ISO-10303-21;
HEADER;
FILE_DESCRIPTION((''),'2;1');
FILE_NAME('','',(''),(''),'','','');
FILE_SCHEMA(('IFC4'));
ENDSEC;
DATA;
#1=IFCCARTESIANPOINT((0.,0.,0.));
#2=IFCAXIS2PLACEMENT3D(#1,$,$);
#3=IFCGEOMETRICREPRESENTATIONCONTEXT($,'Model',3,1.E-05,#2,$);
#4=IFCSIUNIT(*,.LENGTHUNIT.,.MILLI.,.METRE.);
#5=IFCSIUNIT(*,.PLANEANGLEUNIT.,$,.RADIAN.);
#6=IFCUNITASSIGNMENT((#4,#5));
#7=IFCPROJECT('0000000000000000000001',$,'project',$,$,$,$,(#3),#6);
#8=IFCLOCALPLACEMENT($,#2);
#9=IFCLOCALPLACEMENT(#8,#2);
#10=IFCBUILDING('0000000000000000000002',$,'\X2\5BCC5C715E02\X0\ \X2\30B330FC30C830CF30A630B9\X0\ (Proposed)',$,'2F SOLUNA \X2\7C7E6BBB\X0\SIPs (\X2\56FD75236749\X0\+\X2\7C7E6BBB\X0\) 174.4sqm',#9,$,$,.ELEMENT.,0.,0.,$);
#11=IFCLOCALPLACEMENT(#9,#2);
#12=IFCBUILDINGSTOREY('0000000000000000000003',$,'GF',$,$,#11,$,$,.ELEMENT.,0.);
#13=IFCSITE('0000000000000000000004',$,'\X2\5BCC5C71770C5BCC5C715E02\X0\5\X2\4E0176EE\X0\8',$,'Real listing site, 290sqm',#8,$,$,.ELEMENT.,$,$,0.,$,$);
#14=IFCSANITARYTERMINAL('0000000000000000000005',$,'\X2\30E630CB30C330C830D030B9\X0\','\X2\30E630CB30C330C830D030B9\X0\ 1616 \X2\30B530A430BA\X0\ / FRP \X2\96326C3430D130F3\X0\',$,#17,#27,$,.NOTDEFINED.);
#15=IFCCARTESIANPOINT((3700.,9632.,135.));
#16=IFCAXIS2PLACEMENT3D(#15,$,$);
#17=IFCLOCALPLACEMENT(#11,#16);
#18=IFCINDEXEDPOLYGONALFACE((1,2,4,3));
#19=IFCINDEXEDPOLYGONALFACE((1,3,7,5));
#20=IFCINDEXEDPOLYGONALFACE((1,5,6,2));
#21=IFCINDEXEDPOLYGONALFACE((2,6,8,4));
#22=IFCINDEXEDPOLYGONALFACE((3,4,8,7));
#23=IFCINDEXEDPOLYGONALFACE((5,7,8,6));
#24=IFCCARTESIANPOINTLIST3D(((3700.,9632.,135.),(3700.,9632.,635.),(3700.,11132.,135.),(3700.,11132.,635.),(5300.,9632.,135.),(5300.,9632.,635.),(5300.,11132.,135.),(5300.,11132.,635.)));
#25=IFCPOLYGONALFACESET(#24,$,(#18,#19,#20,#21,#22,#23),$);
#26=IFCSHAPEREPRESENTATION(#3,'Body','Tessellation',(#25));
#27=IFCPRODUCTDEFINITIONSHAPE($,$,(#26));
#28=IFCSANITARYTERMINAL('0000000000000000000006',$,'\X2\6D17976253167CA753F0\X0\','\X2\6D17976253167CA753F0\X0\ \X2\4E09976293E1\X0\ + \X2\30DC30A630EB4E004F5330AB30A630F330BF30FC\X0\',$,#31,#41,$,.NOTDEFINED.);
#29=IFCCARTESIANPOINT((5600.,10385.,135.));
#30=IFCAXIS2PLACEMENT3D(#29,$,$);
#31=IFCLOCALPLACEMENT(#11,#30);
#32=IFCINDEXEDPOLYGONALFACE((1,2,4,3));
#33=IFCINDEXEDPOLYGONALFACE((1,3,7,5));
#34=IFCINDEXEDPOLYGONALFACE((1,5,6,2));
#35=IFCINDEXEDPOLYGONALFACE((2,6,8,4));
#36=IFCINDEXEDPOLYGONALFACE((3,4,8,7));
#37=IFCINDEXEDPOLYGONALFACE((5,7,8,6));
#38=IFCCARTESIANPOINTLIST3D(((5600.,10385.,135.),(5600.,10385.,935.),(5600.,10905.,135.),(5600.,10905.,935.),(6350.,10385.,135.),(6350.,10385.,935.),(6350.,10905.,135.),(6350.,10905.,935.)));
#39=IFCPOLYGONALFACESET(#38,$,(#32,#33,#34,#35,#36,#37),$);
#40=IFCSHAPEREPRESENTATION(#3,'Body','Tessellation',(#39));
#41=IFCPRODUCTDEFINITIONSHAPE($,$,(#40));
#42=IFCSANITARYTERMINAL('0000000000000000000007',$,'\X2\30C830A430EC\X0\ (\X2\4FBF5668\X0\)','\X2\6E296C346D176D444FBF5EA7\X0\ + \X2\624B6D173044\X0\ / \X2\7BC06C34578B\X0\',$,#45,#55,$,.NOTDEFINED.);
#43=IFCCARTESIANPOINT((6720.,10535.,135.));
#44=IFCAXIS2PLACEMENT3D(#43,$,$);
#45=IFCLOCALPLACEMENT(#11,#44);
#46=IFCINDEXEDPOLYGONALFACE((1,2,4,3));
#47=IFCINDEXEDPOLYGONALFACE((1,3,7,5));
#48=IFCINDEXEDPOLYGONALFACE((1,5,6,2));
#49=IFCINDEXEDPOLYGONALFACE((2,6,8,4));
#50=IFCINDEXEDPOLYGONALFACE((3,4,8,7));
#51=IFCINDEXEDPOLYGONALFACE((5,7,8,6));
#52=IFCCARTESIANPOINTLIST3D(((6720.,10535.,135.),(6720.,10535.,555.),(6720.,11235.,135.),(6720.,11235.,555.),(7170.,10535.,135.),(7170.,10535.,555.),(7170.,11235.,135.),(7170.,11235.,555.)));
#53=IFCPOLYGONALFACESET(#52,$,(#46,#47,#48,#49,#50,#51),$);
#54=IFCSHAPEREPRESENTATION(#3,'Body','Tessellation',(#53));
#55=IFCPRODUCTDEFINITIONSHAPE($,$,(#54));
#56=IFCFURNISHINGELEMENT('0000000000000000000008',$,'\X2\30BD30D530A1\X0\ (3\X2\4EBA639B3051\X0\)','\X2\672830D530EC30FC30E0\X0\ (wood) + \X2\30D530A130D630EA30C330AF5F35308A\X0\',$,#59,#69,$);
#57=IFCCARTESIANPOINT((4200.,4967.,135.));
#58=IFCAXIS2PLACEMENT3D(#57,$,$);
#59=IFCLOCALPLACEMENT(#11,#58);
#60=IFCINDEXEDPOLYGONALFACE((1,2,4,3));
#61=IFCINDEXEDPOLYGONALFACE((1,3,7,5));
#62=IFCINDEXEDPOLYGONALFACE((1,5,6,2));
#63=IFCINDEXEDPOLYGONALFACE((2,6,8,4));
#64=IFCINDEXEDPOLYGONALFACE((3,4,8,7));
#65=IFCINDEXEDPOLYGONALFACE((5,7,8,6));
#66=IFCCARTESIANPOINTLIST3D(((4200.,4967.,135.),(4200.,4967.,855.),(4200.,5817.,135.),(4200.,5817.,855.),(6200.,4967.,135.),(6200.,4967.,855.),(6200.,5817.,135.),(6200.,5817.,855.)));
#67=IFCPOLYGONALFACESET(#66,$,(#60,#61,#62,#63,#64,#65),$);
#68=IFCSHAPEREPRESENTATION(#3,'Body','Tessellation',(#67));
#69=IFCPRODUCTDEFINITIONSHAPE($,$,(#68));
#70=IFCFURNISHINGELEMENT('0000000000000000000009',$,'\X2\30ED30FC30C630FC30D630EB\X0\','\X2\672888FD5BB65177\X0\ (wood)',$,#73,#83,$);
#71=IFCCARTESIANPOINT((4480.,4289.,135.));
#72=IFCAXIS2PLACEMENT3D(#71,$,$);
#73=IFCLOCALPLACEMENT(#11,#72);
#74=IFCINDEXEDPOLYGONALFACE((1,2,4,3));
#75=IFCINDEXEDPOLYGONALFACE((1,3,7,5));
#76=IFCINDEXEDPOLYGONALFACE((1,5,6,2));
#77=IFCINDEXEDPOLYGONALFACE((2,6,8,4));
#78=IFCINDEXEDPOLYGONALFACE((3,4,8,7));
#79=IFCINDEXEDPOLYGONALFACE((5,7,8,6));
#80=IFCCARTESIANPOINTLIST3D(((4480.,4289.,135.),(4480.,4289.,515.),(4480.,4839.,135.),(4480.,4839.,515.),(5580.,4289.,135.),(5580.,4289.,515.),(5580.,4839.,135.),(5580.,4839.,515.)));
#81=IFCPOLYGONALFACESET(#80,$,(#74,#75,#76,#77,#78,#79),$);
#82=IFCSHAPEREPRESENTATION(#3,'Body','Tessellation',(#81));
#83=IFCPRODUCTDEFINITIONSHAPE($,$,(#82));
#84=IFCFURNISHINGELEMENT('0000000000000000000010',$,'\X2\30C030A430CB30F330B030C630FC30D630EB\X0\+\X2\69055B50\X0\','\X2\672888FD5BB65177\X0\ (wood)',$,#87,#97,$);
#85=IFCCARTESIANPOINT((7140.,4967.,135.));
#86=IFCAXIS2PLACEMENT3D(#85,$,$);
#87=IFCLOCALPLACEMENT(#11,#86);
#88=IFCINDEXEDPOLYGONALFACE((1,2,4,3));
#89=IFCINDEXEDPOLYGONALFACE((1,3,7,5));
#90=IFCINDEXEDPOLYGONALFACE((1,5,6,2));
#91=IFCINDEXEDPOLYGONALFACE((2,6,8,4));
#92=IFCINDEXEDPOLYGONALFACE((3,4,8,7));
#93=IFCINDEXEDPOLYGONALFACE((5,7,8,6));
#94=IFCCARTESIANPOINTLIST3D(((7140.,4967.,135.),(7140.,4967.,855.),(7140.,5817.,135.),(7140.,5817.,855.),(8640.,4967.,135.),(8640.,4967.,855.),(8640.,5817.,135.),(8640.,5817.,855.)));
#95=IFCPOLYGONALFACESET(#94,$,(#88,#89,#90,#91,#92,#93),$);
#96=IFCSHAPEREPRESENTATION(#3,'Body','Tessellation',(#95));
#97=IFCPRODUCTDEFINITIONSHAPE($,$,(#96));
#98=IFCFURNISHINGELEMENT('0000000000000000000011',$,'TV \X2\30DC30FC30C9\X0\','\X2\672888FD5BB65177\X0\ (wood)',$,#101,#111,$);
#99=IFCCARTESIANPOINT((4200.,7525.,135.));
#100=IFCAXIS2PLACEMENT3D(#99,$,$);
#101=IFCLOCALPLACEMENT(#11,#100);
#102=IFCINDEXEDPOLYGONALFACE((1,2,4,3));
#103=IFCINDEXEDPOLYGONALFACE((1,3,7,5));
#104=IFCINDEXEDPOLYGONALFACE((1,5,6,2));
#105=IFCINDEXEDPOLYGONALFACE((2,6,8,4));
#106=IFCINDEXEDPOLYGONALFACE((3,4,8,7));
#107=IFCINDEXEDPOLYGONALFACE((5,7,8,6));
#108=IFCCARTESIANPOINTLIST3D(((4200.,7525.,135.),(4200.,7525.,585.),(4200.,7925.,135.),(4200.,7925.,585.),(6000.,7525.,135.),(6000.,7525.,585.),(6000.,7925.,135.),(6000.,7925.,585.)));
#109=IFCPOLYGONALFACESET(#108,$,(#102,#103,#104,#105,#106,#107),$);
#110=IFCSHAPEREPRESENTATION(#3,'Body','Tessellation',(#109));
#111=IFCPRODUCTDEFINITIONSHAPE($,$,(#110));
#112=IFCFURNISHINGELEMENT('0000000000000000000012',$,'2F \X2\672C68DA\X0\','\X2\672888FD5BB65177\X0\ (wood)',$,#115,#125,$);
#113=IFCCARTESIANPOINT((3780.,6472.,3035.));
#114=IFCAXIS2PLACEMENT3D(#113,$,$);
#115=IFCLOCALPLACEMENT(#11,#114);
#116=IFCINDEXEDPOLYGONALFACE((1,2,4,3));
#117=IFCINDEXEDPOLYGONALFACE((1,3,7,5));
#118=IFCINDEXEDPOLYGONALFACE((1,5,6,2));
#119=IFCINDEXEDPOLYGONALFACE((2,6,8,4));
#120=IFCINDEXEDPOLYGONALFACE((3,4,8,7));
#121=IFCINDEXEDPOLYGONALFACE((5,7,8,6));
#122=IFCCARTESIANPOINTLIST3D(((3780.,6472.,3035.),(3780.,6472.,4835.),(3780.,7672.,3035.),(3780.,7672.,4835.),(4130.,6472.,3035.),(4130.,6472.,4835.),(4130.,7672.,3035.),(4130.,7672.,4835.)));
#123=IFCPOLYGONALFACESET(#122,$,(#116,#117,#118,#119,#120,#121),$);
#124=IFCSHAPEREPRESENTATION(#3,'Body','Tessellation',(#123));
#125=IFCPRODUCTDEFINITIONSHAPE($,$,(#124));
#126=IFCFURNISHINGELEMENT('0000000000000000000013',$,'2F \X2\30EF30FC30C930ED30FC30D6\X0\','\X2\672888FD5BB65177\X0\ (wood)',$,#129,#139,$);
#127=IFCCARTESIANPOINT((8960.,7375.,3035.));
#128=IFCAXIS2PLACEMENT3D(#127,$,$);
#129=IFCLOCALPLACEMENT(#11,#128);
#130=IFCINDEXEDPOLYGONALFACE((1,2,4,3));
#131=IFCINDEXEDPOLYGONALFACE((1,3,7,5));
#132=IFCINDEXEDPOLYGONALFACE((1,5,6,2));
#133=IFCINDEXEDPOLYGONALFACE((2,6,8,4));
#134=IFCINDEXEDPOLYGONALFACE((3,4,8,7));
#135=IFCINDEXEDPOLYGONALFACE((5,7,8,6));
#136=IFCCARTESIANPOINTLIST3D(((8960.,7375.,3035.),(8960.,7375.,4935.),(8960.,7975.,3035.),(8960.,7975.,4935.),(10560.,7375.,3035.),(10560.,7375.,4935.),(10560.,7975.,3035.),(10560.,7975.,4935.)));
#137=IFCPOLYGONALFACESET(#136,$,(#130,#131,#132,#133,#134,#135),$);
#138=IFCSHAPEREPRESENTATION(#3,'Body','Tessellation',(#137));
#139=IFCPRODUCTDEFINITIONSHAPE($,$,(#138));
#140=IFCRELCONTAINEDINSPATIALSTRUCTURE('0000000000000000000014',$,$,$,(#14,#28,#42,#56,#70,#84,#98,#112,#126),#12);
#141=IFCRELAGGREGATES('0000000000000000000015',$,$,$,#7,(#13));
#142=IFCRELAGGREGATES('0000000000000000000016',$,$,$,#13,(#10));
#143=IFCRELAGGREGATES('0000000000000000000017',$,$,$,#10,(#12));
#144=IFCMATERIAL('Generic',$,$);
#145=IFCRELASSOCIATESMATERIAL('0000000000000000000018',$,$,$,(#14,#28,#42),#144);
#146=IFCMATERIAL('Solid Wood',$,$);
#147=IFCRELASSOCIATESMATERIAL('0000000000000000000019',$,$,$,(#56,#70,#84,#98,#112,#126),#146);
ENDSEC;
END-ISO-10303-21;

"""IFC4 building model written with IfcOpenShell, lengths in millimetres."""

from ifc_helpers import new_model, si_unit, frame, frame_2d, origin, place, context, project, spatial, rectangle, extrude, material, element, save


model = new_model("IFC4")

# Units and contexts
model_context = context("Model", 3, precision=1e-05, world=origin())
ifc_project = project(units=[si_unit("LENGTHUNIT", "METRE", prefix="MILLI"), si_unit("PLANEANGLEUNIT", "RADIAN")], contexts=[model_context])

# Site, building, storey
site_placement = place(None, origin())
site = spatial("IfcSite", under=ifc_project, at=site_placement, Name="富山県富山市5丁目8", ObjectType="Real listing site, 290sqm", CompositionType="ELEMENT", RefElevation=0.0)
building_placement = place(site_placement, origin())
building = spatial("IfcBuilding", under=site, at=building_placement, Name="富山市 コートハウス (Proposed)", ObjectType="2F SOLUNA 籾殻SIPs (国産杉+籾殻) 174.4sqm", CompositionType="ELEMENT", ElevationOfRefHeight=0.0, ElevationOfTerrain=0.0)
storey_placement = place(building_placement, origin())
storey = spatial("IfcBuildingStorey", under=building, at=storey_placement, Name="GF", CompositionType="ELEMENT", Elevation=0.0)

# Shared definitions
ifc_material_1 = material(Name="Generic")

# Shared definitions
ifc_material_2 = material(Name="Solid Wood")

# Sanitary terminals
sanitary_terminal_1_placement = place(storey_placement, frame((3700.0, 9632.0, 135.0)))
element("IfcSanitaryTerminal", 1, at=sanitary_terminal_1_placement, inside=storey, material=ifc_material_1, Name="ユニットバス", Description="ユニットバス 1616 サイズ / FRP 防水パン", PredefinedType="NOTDEFINED", context=model_context, shape_type="SweptSolid", body=[
    extrude(rectangle(XDim=1600.0, YDim=1500.0, at=frame_2d((800.0, 750.0))), frame((3700.0, 9632.0, 135.0)), (0.0, 0.0, 1.0), 500.0),
])
sanitary_terminal_2_placement = place(storey_placement, frame((5600.0, 10385.0, 135.0)))
element("IfcSanitaryTerminal", 2, at=sanitary_terminal_2_placement, inside=storey, material=ifc_material_1, Name="洗面化粧台", Description="洗面化粧台 三面鏡 + ボウル一体カウンター", PredefinedType="NOTDEFINED", context=model_context, shape_type="SweptSolid", body=[
    extrude(rectangle(XDim=750.0, YDim=520.0, at=frame_2d((375.0, 260.0))), frame((5600.0, 10385.0, 135.0)), (0.0, 0.0, 1.0), 800.0),
])
sanitary_terminal_3_placement = place(storey_placement, frame((6720.0, 10535.0, 135.0)))
element("IfcSanitaryTerminal", 3, at=sanitary_terminal_3_placement, inside=storey, material=ifc_material_1, Name="トイレ (便器)", Description="温水洗浄便座 + 手洗い / 節水型", PredefinedType="NOTDEFINED", context=model_context, shape_type="SweptSolid", body=[
    extrude(rectangle(XDim=450.0, YDim=700.0, at=frame_2d((225.0, 350.0))), frame((6720.0, 10535.0, 135.0)), (0.0, 0.0, 1.0), 420.0),
])

# Furnishing elements
furnishing_1_placement = place(storey_placement, frame((4200.0, 4967.0, 135.0)))
element("IfcFurnishingElement", 4, at=furnishing_1_placement, inside=storey, material=ifc_material_2, Name="ソファ (3人掛け)", Description="木フレーム (wood) + ファブリック張り", context=model_context, shape_type="SweptSolid", body=[
    extrude(rectangle(XDim=2000.0, YDim=850.0, at=frame_2d((1000.0, 425.0))), frame((4200.0, 4967.0, 135.0)), (0.0, 0.0, 1.0), 720.0),
])
furnishing_2_placement = place(storey_placement, frame((4480.0, 4289.0, 135.0)))
element("IfcFurnishingElement", 5, at=furnishing_2_placement, inside=storey, material=ifc_material_2, Name="ローテーブル", Description="木製家具 (wood)", context=model_context, shape_type="SweptSolid", body=[
    extrude(rectangle(XDim=1100.0, YDim=550.0, at=frame_2d((550.0, 275.0))), frame((4480.0, 4289.0, 135.0)), (0.0, 0.0, 1.0), 380.0),
])
furnishing_3_placement = place(storey_placement, frame((7140.0, 4967.0, 135.0)))
element("IfcFurnishingElement", 6, at=furnishing_3_placement, inside=storey, material=ifc_material_2, Name="ダイニングテーブル+椅子", Description="木製家具 (wood)", context=model_context, shape_type="SweptSolid", body=[
    extrude(rectangle(XDim=1500.0, YDim=850.0, at=frame_2d((750.0, 425.0))), frame((7140.0, 4967.0, 135.0)), (0.0, 0.0, 1.0), 720.0),
])
furnishing_4_placement = place(storey_placement, frame((4200.0, 7525.0, 135.0)))
element("IfcFurnishingElement", 7, at=furnishing_4_placement, inside=storey, material=ifc_material_2, Name="TV ボード", Description="木製家具 (wood)", context=model_context, shape_type="SweptSolid", body=[
    extrude(rectangle(XDim=1800.0, YDim=400.0, at=frame_2d((900.0, 200.0))), frame((4200.0, 7525.0, 135.0)), (0.0, 0.0, 1.0), 450.0),
])
furnishing_5_placement = place(storey_placement, frame((3780.0, 6472.0, 3035.0)))
element("IfcFurnishingElement", 8, at=furnishing_5_placement, inside=storey, material=ifc_material_2, Name="2F 本棚", Description="木製家具 (wood)", context=model_context, shape_type="SweptSolid", body=[
    extrude(rectangle(XDim=350.0, YDim=1200.0, at=frame_2d((175.0, 600.0))), frame((3780.0, 6472.0, 3035.0)), (0.0, 0.0, 1.0), 1800.0),
])
furnishing_6_placement = place(storey_placement, frame((8960.0, 7375.0, 3035.0)))
element("IfcFurnishingElement", 9, at=furnishing_6_placement, inside=storey, material=ifc_material_2, Name="2F ワードローブ", Description="木製家具 (wood)", context=model_context, shape_type="SweptSolid", body=[
    extrude(rectangle(XDim=1600.0, YDim=600.0, at=frame_2d((800.0, 300.0))), frame((8960.0, 7375.0, 3035.0)), (0.0, 0.0, 1.0), 1900.0),
])

save(model, "model.ifc")
